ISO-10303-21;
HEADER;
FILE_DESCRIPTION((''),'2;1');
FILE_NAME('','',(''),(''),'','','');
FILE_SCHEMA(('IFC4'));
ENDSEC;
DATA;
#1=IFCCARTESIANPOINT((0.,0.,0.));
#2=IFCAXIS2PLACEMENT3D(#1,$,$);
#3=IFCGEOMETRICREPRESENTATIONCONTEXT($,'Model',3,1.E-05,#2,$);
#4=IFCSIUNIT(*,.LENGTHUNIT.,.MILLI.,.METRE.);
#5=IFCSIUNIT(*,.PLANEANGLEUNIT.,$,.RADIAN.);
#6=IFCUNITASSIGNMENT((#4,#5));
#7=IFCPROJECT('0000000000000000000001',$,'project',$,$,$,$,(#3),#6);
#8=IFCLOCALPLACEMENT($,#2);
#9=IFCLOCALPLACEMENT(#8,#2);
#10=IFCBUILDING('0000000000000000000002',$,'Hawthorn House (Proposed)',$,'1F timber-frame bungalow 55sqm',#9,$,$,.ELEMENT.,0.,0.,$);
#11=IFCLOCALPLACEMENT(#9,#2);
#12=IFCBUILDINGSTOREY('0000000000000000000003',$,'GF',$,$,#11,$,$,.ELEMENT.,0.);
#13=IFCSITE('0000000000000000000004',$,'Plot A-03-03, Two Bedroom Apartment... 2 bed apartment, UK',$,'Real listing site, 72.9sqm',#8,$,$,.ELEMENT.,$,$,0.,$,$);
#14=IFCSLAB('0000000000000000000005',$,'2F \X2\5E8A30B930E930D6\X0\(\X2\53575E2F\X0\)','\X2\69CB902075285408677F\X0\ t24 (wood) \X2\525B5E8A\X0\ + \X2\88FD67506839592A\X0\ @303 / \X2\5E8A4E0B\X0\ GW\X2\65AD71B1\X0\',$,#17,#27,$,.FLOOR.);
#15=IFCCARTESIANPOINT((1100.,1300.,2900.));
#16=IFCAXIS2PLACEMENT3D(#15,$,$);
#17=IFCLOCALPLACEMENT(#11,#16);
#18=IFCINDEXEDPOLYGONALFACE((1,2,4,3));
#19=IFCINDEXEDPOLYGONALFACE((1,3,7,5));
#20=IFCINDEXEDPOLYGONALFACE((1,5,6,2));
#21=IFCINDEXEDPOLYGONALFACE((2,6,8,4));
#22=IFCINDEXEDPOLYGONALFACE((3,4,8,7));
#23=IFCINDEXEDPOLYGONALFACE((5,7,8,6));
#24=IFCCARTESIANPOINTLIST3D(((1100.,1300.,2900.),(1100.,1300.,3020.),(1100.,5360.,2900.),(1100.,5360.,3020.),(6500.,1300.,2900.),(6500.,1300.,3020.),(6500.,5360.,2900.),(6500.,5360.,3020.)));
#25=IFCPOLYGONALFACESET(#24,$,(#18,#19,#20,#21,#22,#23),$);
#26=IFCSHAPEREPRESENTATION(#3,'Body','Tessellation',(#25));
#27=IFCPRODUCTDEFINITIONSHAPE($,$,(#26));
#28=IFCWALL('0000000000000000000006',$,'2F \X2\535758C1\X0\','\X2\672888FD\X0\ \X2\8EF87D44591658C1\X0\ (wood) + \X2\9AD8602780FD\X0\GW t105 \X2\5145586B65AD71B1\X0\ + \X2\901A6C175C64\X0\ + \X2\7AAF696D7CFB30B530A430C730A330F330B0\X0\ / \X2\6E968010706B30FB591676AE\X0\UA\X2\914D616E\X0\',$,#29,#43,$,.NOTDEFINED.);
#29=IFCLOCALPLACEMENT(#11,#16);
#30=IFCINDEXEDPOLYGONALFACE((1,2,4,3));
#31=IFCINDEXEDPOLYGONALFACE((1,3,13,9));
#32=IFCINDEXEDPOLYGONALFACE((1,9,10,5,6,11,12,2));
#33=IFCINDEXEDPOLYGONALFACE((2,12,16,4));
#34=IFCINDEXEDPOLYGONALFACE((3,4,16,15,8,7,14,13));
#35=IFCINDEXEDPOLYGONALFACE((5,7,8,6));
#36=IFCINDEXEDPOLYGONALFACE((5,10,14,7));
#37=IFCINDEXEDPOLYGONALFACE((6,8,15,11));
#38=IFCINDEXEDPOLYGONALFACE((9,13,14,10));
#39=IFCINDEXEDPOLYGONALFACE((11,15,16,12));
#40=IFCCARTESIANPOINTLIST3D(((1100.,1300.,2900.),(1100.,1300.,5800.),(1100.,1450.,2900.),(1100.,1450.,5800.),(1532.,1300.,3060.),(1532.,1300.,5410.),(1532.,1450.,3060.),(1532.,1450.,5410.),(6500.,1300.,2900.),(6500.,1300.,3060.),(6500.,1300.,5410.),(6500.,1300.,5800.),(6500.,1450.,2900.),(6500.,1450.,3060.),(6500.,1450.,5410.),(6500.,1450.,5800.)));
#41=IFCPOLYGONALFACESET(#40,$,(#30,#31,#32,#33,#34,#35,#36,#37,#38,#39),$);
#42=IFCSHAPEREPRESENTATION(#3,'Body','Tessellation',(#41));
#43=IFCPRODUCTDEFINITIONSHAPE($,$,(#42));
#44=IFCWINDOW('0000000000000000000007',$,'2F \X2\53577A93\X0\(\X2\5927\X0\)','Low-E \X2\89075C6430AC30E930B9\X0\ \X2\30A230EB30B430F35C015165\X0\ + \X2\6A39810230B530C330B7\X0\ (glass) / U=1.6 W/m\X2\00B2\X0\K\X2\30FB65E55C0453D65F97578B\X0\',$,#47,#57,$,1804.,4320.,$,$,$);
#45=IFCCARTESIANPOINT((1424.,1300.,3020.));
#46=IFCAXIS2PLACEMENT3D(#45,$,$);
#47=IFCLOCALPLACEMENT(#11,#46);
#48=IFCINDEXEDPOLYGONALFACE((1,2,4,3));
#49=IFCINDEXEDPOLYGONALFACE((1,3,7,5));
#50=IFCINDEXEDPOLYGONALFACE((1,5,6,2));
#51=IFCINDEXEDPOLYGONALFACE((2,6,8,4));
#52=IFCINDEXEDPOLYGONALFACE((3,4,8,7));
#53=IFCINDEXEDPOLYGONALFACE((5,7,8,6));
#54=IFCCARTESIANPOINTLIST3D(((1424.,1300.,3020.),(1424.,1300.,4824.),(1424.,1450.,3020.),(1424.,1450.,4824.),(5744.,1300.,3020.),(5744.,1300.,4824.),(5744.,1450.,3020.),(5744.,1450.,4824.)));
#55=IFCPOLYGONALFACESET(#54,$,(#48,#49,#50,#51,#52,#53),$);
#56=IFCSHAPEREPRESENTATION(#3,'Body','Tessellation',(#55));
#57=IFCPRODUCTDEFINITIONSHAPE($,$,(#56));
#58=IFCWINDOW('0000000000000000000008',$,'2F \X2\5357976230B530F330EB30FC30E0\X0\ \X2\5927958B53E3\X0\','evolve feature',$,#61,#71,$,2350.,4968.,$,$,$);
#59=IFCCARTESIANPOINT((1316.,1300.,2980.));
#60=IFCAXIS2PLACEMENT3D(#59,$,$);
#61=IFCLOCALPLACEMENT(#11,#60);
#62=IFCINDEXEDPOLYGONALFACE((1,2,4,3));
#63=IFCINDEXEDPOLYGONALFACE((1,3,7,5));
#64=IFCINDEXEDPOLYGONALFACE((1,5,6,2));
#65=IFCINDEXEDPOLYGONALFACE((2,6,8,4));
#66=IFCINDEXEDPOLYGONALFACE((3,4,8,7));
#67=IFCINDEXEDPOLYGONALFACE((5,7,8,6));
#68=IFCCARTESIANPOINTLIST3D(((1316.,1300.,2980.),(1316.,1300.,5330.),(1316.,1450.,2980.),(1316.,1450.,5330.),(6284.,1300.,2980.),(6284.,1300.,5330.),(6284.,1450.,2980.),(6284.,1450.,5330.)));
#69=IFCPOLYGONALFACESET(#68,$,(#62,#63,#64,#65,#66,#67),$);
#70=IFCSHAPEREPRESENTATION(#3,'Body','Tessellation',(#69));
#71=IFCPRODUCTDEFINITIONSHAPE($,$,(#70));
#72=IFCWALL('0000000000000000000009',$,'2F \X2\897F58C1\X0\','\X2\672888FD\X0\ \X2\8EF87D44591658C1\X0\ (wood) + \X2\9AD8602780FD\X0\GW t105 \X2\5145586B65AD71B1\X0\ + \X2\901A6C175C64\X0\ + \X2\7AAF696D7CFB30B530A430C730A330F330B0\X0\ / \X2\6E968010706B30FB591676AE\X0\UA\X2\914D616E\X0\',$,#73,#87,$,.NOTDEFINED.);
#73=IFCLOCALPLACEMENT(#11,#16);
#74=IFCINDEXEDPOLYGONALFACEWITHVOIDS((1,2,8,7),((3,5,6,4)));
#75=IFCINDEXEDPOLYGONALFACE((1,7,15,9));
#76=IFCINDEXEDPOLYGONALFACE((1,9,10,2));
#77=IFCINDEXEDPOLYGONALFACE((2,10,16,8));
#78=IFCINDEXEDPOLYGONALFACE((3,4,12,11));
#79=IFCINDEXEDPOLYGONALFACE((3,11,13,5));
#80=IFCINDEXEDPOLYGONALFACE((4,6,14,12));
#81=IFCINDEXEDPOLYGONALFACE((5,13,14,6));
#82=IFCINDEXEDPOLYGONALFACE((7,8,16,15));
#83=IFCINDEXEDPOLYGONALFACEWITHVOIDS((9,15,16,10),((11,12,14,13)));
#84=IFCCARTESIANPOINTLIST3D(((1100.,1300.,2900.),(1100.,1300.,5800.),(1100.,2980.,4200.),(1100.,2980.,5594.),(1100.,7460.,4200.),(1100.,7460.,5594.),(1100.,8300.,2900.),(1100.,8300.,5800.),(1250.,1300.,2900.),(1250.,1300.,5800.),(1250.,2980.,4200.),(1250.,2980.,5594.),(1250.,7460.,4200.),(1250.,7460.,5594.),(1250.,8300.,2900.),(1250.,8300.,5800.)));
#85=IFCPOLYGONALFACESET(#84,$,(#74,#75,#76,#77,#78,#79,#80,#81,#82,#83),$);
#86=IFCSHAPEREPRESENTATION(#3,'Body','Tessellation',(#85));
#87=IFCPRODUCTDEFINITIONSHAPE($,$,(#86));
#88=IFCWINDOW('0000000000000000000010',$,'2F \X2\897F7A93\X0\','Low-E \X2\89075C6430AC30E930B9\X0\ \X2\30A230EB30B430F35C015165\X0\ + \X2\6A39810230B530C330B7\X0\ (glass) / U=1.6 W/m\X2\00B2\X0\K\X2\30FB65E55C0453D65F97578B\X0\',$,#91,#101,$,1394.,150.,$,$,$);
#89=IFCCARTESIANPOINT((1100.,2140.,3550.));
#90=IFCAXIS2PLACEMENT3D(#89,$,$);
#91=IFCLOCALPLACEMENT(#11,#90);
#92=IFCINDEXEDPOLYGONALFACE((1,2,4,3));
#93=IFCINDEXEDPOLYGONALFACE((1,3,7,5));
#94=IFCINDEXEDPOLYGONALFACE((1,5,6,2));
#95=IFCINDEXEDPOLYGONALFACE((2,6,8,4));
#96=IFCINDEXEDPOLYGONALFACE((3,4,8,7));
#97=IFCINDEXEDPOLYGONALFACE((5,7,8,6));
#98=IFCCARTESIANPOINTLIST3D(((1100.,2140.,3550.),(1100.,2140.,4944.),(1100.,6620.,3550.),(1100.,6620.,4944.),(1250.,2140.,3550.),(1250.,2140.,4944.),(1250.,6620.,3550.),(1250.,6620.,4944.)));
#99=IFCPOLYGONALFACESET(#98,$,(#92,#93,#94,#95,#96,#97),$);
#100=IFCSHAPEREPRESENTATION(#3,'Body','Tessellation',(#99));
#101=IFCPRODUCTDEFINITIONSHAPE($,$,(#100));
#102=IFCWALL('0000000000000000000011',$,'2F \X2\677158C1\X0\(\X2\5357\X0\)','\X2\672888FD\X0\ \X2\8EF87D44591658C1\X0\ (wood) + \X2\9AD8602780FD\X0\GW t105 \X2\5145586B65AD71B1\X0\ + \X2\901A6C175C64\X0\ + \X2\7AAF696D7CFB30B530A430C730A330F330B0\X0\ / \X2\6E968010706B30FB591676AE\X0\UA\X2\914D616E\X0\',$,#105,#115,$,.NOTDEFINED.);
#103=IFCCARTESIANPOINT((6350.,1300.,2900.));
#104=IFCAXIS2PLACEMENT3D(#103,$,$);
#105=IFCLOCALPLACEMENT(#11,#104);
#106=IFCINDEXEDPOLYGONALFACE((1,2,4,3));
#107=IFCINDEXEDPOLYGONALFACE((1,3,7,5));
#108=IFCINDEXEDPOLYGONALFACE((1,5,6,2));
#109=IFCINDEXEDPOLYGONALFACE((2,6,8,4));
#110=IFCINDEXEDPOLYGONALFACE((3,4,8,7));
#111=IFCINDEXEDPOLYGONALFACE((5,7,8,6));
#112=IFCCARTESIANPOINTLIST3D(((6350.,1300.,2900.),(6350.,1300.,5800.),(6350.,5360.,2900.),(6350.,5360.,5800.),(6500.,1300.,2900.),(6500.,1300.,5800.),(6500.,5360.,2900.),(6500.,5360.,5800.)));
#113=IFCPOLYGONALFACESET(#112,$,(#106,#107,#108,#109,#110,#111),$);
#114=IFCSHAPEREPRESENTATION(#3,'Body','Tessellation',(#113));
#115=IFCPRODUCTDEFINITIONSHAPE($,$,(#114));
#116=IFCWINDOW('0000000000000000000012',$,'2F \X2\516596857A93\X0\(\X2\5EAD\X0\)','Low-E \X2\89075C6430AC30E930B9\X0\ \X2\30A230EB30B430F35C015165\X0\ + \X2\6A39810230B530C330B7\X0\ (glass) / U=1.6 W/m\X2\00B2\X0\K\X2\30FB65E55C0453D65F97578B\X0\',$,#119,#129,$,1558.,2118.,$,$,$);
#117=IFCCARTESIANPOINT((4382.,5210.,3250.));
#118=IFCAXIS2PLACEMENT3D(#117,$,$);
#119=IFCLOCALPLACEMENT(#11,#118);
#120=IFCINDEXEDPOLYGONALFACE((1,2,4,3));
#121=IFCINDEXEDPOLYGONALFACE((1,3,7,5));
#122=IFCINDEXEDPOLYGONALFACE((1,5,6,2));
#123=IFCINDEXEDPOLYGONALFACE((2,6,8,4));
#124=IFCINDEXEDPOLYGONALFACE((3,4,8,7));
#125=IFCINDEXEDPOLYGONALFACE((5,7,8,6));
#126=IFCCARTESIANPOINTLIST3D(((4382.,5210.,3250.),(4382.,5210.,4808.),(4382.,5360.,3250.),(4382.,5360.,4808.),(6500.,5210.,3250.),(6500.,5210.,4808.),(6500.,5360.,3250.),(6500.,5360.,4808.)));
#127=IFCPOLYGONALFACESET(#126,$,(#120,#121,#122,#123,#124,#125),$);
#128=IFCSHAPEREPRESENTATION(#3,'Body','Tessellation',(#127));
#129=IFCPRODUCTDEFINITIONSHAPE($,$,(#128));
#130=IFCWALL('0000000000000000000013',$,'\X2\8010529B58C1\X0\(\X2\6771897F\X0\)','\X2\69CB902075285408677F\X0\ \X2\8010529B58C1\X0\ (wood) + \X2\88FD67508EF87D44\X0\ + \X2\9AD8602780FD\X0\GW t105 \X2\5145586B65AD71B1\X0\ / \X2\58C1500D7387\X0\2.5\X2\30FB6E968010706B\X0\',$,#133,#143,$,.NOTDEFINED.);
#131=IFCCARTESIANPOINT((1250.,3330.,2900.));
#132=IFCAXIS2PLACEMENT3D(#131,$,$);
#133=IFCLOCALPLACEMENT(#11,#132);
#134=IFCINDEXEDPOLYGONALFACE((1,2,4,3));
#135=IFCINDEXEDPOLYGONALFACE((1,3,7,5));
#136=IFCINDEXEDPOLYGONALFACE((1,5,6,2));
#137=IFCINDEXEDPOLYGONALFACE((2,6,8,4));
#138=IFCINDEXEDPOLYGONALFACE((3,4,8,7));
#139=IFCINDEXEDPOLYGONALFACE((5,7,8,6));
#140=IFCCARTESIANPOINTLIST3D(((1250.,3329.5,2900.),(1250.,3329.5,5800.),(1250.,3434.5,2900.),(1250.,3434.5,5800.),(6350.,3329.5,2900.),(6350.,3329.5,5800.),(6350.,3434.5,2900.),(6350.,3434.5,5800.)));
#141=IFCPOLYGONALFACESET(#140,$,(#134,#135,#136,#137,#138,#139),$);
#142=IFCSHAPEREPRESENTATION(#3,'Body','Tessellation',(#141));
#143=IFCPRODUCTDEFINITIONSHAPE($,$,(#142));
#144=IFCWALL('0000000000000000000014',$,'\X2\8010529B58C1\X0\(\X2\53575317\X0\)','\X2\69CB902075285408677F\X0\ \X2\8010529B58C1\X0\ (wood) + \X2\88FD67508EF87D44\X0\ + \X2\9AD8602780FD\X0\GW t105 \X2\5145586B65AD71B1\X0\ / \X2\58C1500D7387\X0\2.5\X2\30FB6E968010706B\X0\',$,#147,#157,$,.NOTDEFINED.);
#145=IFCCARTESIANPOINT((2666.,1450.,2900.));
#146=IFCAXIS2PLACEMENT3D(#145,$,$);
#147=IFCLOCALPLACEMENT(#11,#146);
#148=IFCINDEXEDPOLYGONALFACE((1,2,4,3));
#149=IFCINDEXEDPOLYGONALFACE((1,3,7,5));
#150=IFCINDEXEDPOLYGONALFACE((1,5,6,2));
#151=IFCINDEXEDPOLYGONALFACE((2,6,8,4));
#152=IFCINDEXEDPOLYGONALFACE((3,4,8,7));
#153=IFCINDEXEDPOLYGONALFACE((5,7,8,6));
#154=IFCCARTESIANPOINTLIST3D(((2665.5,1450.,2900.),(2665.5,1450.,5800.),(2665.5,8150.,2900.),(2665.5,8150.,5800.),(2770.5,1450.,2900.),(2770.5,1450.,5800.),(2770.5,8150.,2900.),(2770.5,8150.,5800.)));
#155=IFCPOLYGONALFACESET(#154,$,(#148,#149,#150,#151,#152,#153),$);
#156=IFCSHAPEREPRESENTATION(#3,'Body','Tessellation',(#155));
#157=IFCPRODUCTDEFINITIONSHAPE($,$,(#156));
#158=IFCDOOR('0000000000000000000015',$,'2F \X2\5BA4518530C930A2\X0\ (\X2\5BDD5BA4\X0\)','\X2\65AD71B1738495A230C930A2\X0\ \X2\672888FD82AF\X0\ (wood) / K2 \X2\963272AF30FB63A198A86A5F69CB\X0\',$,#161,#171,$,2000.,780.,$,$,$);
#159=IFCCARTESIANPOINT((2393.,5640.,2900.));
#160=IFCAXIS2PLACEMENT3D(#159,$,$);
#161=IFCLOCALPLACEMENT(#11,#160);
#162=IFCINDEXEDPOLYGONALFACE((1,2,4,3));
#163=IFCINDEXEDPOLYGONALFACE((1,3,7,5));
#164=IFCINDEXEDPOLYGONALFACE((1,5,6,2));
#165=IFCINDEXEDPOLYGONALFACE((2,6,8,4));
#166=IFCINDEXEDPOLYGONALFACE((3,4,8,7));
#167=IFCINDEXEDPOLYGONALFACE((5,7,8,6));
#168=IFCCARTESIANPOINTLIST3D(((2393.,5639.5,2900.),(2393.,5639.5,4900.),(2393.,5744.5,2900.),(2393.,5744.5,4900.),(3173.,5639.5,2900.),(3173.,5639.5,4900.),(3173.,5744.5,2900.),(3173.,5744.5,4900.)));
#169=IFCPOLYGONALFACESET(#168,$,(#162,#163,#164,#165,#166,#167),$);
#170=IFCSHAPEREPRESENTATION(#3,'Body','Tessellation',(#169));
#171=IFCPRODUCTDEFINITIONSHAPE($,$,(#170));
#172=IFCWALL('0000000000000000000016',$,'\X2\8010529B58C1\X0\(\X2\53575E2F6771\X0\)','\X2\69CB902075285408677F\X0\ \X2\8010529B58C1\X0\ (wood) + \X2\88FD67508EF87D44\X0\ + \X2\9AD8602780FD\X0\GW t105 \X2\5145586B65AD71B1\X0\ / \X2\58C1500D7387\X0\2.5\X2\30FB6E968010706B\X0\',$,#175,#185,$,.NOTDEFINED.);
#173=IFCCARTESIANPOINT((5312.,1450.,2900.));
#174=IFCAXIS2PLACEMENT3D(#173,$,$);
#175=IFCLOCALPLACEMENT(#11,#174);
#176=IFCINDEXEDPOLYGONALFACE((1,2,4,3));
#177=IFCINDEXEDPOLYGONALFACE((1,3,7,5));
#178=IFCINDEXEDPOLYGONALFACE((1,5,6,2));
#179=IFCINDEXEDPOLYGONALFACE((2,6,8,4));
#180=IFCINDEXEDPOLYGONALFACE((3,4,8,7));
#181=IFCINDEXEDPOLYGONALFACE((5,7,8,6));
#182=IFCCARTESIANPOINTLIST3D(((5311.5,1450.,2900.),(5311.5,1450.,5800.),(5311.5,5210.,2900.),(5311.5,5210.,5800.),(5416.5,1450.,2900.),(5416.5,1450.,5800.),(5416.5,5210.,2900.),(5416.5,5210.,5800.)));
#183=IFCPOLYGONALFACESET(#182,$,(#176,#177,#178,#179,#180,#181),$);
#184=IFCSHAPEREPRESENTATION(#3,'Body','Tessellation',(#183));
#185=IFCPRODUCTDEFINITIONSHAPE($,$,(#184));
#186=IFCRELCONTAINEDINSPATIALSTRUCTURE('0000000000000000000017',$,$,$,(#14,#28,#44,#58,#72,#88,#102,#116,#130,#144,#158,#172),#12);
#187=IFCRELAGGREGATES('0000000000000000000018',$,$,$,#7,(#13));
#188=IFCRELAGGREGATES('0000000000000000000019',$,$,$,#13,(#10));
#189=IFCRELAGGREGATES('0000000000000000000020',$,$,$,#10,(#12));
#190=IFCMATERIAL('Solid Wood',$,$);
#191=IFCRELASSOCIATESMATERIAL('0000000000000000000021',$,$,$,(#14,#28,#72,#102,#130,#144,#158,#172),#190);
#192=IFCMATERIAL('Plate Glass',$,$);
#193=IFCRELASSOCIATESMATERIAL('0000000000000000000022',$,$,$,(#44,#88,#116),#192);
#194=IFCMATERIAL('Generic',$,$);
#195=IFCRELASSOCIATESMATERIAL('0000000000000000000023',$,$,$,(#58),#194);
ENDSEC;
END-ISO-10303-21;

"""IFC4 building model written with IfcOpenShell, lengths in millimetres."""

from ifc_helpers import new_model, si_unit, frame, frame_2d, origin, place, context, project, spatial, rectangle, extrude, material, element, fill, save


model = new_model("IFC4")

# Units and contexts
model_context = context("Model", 3, precision=1e-05, world=origin())
ifc_project = project(units=[si_unit("LENGTHUNIT", "METRE", prefix="MILLI"), si_unit("PLANEANGLEUNIT", "RADIAN")], contexts=[model_context])

# Site, building, storey
site_placement = place(None, origin())
site = spatial("IfcSite", under=ifc_project, at=site_placement, Name="Plot A-03-03, Two Bedroom Apartment... 2 bed apartment, UK", ObjectType="Real listing site, 72.9sqm", CompositionType="ELEMENT", RefElevation=0.0)
building_placement = place(site_placement, origin())
building = spatial("IfcBuilding", under=site, at=building_placement, Name="Hawthorn House (Proposed)", ObjectType="1F timber-frame bungalow 55sqm", CompositionType="ELEMENT", ElevationOfRefHeight=0.0, ElevationOfTerrain=0.0)
storey_placement = place(building_placement, origin())
storey = spatial("IfcBuildingStorey", under=building, at=storey_placement, Name="GF", CompositionType="ELEMENT", Elevation=0.0)

# Slab
ifc_material_1 = material(Name="Solid Wood")
slab_placement = place(storey_placement, frame((1100.0, 1300.0, 2900.0)))
element("IfcSlab", 1, at=slab_placement, inside=storey, material=ifc_material_1, Name="2F 床スラブ(南帯)", Description="構造用合板 t24 (wood) 剛床 + 製材根太 @303 / 床下 GW断熱", PredefinedType="FLOOR", context=model_context, shape_type="SweptSolid", body=[
    extrude(rectangle(XDim=5400.0, YDim=4060.0, at=frame_2d((2700.0, 2030.0))), frame((1100.0, 1300.0, 2900.0)), (0.0, 0.0, 1.0), 120.0),
])

# Wall, openings, windows
wall_1_placement = place(storey_placement, frame((1100.0, 1300.0, 2900.0)))
wall_1 = element("IfcWall", 2, at=wall_1_placement, inside=storey, material=ifc_material_1, Name="2F 南壁", Description="木製 軸組外壁 (wood) + 高性能GW t105 充填断熱 + 通気層 + 窯業系サイディング / 準耐火・外皮UA配慮", PredefinedType="NOTDEFINED", context=model_context, shape_type="SweptSolid", body=[
    extrude(rectangle(XDim=5400.0, YDim=150.0, at=frame_2d((2700.0, 75.0))), frame((1100.0, 1300.0, 2900.0)), (0.0, 0.0, 1.0), 2900.0),
])
opening_1_placement = place(storey_placement, frame((1424.0, 1300.0, 3020.0)))
opening_1 = element("IfcOpeningElement", 3, at=opening_1_placement, cuts=wall_1, PredefinedType="NOTDEFINED", context=model_context, shape_type="SweptSolid", body=[
    extrude(rectangle(XDim=4320.0, YDim=150.0, at=frame_2d((2160.0, 75.0))), frame((1424.0, 1300.0, 3020.0)), (0.0, 0.0, 1.0), 1804.0),
])
opening_2_placement = place(storey_placement, frame((1316.0, 1300.0, 2980.0)))
opening_2 = element("IfcOpeningElement", 4, at=opening_2_placement, cuts=wall_1, PredefinedType="NOTDEFINED", context=model_context, shape_type="SweptSolid", body=[
    extrude(rectangle(XDim=4968.0, YDim=150.0, at=frame_2d((2484.0, 75.0))), frame((1316.0, 1300.0, 2980.0)), (0.0, 0.0, 1.0), 2350.0),
])
ifc_material_2 = material(Name="Plate Glass")
window_1_placement = place(storey_placement, frame((1424.0, 1300.0, 3020.0)))
window_1 = element("IfcWindow", 5, at=window_1_placement, inside=storey, material=ifc_material_2, Name="2F 南窓(大)", Description="Low-E 複層ガラス アルゴン封入 + 樹脂サッシ (glass) / U=1.6 W/m²K・日射取得型", OverallHeight=1804.0, OverallWidth=4320.0, context=model_context, shape_type="SweptSolid", body=[
    extrude(rectangle(XDim=4320.0, YDim=150.0, at=frame_2d((2160.0, 75.0))), frame((1424.0, 1300.0, 3020.0)), (0.0, 0.0, 1.0), 1804.0),
])
fill(opening_1, window_1)
ifc_material_3 = material(Name="Generic")
window_2_placement = place(storey_placement, frame((1316.0, 1300.0, 2980.0)))
window_2 = element("IfcWindow", 6, at=window_2_placement, inside=storey, material=ifc_material_3, Name="2F 南面サンルーム 大開口", Description="evolve feature", OverallHeight=2350.0, OverallWidth=4968.0, context=model_context, shape_type="SweptSolid", body=[
    extrude(rectangle(XDim=4968.0, YDim=150.0, at=frame_2d((2484.0, 75.0))), frame((1316.0, 1300.0, 2980.0)), (0.0, 0.0, 1.0), 2350.0),
])
fill(opening_2, window_2)

# Walls, openings, windows
wall_2_placement = place(storey_placement, frame((1100.0, 1300.0, 2900.0)))
wall_2 = element("IfcWall", 7, at=wall_2_placement, inside=storey, material=ifc_material_1, Name="2F 西壁", Description="木製 軸組外壁 (wood) + 高性能GW t105 充填断熱 + 通気層 + 窯業系サイディング / 準耐火・外皮UA配慮", PredefinedType="NOTDEFINED", context=model_context, shape_type="SweptSolid", body=[
    extrude(rectangle(XDim=150.0, YDim=7000.0, at=frame_2d((75.0, 3500.0))), frame((1100.0, 1300.0, 2900.0)), (0.0, 0.0, 1.0), 2900.0),
])
opening_3_placement = place(storey_placement, frame((1100.0, 2140.0, 3550.0)))
opening_3 = element("IfcOpeningElement", 8, at=opening_3_placement, cuts=wall_2, PredefinedType="NOTDEFINED", context=model_context, shape_type="SweptSolid", body=[
    extrude(rectangle(XDim=150.0, YDim=4480.0, at=frame_2d((75.0, 2240.0))), frame((1100.0, 2140.0, 3550.0)), (0.0, 0.0, 1.0), 1394.0),
])
window_3_placement = place(storey_placement, frame((1100.0, 2140.0, 3550.0)))
window_3 = element("IfcWindow", 9, at=window_3_placement, inside=storey, material=ifc_material_2, Name="2F 西窓", Description="Low-E 複層ガラス アルゴン封入 + 樹脂サッシ (glass) / U=1.6 W/m²K・日射取得型", OverallHeight=1394.0, OverallWidth=150.0, context=model_context, shape_type="SweptSolid", body=[
    extrude(rectangle(XDim=150.0, YDim=4480.0, at=frame_2d((75.0, 2240.0))), frame((1100.0, 2140.0, 3550.0)), (0.0, 0.0, 1.0), 1394.0),
])
fill(opening_3, window_3)
wall_3_placement = place(storey_placement, frame((6350.0, 1300.0, 2900.0)))
wall_3 = element("IfcWall", 10, at=wall_3_placement, inside=storey, material=ifc_material_1, Name="2F 東壁(南)", Description="木製 軸組外壁 (wood) + 高性能GW t105 充填断熱 + 通気層 + 窯業系サイディング / 準耐火・外皮UA配慮", PredefinedType="NOTDEFINED", context=model_context, shape_type="SweptSolid", body=[
    extrude(rectangle(XDim=150.0, YDim=4060.0, at=frame_2d((75.0, 2030.0))), frame((6350.0, 1300.0, 2900.0)), (0.0, 0.0, 1.0), 2900.0),
])
opening_4_placement = place(storey_placement, frame((4382.0, 5210.0, 3250.0)))
opening_4 = element("IfcOpeningElement", 11, at=opening_4_placement, cuts=wall_3, PredefinedType="NOTDEFINED", context=model_context, shape_type="SweptSolid", body=[
    extrude(rectangle(XDim=2118.0, YDim=150.0, at=frame_2d((1059.0, 75.0))), frame((4382.0, 5210.0, 3250.0)), (0.0, 0.0, 1.0), 1558.0),
])
window_4_placement = place(storey_placement, frame((4382.0, 5210.0, 3250.0)))
window_4 = element("IfcWindow", 12, at=window_4_placement, inside=storey, material=ifc_material_2, Name="2F 入隅窓(庭)", Description="Low-E 複層ガラス アルゴン封入 + 樹脂サッシ (glass) / U=1.6 W/m²K・日射取得型", OverallHeight=1558.0, OverallWidth=2118.0, context=model_context, shape_type="SweptSolid", body=[
    extrude(rectangle(XDim=2118.0, YDim=150.0, at=frame_2d((1059.0, 75.0))), frame((4382.0, 5210.0, 3250.0)), (0.0, 0.0, 1.0), 1558.0),
])
fill(opening_4, window_4)

# Wall
wall_4_placement = place(storey_placement, frame((1250.0, 3330.0, 2900.0)))
element("IfcWall", 13, at=wall_4_placement, inside=storey, material=ifc_material_1, Name="耐力壁(東西)", Description="構造用合板 耐力壁 (wood) + 製材軸組 + 高性能GW t105 充填断熱 / 壁倍率2.5・準耐火", PredefinedType="NOTDEFINED", context=model_context, shape_type="SweptSolid", body=[
    extrude(rectangle(XDim=5100.0, YDim=105.0, at=frame_2d((2550.0, 52.0))), frame((1250.0, 3330.0, 2900.0)), (0.0, 0.0, 1.0), 2900.0),
])

# Wall, opening, door
wall_5_placement = place(storey_placement, frame((2666.0, 1450.0, 2900.0)))
wall_5 = element("IfcWall", 14, at=wall_5_placement, inside=storey, material=ifc_material_1, Name="耐力壁(南北)", Description="構造用合板 耐力壁 (wood) + 製材軸組 + 高性能GW t105 充填断熱 / 壁倍率2.5・準耐火", PredefinedType="NOTDEFINED", context=model_context, shape_type="SweptSolid", body=[
    extrude(rectangle(XDim=105.0, YDim=6700.0, at=frame_2d((52.0, 3350.0))), frame((2666.0, 1450.0, 2900.0)), (0.0, 0.0, 1.0), 2900.0),
])
opening_5_placement = place(storey_placement, frame((2393.0, 5640.0, 2900.0)))
opening_5 = element("IfcOpeningElement", 15, at=opening_5_placement, cuts=wall_5, PredefinedType="NOTDEFINED", context=model_context, shape_type="SweptSolid", body=[
    extrude(rectangle(XDim=780.0, YDim=105.0, at=frame_2d((390.0, 52.0))), frame((2393.0, 5640.0, 2900.0)), (0.0, 0.0, 1.0), 2000.0),
])
door_placement = place(storey_placement, frame((2393.0, 5640.0, 2900.0)))
door = element("IfcDoor", 16, at=door_placement, inside=storey, material=ifc_material_1, Name="2F 室内ドア (寝室)", Description="断熱玄関ドア 木製芯 (wood) / K2 防犯・採風機構", OverallHeight=2000.0, OverallWidth=780.0, context=model_context, shape_type="SweptSolid", body=[
    extrude(rectangle(XDim=780.0, YDim=105.0, at=frame_2d((390.0, 52.0))), frame((2393.0, 5640.0, 2900.0)), (0.0, 0.0, 1.0), 2000.0),
])
fill(opening_5, door)

# Wall
wall_6_placement = place(storey_placement, frame((5312.0, 1450.0, 2900.0)))
element("IfcWall", 17, at=wall_6_placement, inside=storey, material=ifc_material_1, Name="耐力壁(南帯東)", Description="構造用合板 耐力壁 (wood) + 製材軸組 + 高性能GW t105 充填断熱 / 壁倍率2.5・準耐火", PredefinedType="NOTDEFINED", context=model_context, shape_type="SweptSolid", body=[
    extrude(rectangle(XDim=105.0, YDim=3760.0, at=frame_2d((52.0, 1880.0))), frame((5312.0, 1450.0, 2900.0)), (0.0, 0.0, 1.0), 2900.0),
])

save(model, "model.ifc")
